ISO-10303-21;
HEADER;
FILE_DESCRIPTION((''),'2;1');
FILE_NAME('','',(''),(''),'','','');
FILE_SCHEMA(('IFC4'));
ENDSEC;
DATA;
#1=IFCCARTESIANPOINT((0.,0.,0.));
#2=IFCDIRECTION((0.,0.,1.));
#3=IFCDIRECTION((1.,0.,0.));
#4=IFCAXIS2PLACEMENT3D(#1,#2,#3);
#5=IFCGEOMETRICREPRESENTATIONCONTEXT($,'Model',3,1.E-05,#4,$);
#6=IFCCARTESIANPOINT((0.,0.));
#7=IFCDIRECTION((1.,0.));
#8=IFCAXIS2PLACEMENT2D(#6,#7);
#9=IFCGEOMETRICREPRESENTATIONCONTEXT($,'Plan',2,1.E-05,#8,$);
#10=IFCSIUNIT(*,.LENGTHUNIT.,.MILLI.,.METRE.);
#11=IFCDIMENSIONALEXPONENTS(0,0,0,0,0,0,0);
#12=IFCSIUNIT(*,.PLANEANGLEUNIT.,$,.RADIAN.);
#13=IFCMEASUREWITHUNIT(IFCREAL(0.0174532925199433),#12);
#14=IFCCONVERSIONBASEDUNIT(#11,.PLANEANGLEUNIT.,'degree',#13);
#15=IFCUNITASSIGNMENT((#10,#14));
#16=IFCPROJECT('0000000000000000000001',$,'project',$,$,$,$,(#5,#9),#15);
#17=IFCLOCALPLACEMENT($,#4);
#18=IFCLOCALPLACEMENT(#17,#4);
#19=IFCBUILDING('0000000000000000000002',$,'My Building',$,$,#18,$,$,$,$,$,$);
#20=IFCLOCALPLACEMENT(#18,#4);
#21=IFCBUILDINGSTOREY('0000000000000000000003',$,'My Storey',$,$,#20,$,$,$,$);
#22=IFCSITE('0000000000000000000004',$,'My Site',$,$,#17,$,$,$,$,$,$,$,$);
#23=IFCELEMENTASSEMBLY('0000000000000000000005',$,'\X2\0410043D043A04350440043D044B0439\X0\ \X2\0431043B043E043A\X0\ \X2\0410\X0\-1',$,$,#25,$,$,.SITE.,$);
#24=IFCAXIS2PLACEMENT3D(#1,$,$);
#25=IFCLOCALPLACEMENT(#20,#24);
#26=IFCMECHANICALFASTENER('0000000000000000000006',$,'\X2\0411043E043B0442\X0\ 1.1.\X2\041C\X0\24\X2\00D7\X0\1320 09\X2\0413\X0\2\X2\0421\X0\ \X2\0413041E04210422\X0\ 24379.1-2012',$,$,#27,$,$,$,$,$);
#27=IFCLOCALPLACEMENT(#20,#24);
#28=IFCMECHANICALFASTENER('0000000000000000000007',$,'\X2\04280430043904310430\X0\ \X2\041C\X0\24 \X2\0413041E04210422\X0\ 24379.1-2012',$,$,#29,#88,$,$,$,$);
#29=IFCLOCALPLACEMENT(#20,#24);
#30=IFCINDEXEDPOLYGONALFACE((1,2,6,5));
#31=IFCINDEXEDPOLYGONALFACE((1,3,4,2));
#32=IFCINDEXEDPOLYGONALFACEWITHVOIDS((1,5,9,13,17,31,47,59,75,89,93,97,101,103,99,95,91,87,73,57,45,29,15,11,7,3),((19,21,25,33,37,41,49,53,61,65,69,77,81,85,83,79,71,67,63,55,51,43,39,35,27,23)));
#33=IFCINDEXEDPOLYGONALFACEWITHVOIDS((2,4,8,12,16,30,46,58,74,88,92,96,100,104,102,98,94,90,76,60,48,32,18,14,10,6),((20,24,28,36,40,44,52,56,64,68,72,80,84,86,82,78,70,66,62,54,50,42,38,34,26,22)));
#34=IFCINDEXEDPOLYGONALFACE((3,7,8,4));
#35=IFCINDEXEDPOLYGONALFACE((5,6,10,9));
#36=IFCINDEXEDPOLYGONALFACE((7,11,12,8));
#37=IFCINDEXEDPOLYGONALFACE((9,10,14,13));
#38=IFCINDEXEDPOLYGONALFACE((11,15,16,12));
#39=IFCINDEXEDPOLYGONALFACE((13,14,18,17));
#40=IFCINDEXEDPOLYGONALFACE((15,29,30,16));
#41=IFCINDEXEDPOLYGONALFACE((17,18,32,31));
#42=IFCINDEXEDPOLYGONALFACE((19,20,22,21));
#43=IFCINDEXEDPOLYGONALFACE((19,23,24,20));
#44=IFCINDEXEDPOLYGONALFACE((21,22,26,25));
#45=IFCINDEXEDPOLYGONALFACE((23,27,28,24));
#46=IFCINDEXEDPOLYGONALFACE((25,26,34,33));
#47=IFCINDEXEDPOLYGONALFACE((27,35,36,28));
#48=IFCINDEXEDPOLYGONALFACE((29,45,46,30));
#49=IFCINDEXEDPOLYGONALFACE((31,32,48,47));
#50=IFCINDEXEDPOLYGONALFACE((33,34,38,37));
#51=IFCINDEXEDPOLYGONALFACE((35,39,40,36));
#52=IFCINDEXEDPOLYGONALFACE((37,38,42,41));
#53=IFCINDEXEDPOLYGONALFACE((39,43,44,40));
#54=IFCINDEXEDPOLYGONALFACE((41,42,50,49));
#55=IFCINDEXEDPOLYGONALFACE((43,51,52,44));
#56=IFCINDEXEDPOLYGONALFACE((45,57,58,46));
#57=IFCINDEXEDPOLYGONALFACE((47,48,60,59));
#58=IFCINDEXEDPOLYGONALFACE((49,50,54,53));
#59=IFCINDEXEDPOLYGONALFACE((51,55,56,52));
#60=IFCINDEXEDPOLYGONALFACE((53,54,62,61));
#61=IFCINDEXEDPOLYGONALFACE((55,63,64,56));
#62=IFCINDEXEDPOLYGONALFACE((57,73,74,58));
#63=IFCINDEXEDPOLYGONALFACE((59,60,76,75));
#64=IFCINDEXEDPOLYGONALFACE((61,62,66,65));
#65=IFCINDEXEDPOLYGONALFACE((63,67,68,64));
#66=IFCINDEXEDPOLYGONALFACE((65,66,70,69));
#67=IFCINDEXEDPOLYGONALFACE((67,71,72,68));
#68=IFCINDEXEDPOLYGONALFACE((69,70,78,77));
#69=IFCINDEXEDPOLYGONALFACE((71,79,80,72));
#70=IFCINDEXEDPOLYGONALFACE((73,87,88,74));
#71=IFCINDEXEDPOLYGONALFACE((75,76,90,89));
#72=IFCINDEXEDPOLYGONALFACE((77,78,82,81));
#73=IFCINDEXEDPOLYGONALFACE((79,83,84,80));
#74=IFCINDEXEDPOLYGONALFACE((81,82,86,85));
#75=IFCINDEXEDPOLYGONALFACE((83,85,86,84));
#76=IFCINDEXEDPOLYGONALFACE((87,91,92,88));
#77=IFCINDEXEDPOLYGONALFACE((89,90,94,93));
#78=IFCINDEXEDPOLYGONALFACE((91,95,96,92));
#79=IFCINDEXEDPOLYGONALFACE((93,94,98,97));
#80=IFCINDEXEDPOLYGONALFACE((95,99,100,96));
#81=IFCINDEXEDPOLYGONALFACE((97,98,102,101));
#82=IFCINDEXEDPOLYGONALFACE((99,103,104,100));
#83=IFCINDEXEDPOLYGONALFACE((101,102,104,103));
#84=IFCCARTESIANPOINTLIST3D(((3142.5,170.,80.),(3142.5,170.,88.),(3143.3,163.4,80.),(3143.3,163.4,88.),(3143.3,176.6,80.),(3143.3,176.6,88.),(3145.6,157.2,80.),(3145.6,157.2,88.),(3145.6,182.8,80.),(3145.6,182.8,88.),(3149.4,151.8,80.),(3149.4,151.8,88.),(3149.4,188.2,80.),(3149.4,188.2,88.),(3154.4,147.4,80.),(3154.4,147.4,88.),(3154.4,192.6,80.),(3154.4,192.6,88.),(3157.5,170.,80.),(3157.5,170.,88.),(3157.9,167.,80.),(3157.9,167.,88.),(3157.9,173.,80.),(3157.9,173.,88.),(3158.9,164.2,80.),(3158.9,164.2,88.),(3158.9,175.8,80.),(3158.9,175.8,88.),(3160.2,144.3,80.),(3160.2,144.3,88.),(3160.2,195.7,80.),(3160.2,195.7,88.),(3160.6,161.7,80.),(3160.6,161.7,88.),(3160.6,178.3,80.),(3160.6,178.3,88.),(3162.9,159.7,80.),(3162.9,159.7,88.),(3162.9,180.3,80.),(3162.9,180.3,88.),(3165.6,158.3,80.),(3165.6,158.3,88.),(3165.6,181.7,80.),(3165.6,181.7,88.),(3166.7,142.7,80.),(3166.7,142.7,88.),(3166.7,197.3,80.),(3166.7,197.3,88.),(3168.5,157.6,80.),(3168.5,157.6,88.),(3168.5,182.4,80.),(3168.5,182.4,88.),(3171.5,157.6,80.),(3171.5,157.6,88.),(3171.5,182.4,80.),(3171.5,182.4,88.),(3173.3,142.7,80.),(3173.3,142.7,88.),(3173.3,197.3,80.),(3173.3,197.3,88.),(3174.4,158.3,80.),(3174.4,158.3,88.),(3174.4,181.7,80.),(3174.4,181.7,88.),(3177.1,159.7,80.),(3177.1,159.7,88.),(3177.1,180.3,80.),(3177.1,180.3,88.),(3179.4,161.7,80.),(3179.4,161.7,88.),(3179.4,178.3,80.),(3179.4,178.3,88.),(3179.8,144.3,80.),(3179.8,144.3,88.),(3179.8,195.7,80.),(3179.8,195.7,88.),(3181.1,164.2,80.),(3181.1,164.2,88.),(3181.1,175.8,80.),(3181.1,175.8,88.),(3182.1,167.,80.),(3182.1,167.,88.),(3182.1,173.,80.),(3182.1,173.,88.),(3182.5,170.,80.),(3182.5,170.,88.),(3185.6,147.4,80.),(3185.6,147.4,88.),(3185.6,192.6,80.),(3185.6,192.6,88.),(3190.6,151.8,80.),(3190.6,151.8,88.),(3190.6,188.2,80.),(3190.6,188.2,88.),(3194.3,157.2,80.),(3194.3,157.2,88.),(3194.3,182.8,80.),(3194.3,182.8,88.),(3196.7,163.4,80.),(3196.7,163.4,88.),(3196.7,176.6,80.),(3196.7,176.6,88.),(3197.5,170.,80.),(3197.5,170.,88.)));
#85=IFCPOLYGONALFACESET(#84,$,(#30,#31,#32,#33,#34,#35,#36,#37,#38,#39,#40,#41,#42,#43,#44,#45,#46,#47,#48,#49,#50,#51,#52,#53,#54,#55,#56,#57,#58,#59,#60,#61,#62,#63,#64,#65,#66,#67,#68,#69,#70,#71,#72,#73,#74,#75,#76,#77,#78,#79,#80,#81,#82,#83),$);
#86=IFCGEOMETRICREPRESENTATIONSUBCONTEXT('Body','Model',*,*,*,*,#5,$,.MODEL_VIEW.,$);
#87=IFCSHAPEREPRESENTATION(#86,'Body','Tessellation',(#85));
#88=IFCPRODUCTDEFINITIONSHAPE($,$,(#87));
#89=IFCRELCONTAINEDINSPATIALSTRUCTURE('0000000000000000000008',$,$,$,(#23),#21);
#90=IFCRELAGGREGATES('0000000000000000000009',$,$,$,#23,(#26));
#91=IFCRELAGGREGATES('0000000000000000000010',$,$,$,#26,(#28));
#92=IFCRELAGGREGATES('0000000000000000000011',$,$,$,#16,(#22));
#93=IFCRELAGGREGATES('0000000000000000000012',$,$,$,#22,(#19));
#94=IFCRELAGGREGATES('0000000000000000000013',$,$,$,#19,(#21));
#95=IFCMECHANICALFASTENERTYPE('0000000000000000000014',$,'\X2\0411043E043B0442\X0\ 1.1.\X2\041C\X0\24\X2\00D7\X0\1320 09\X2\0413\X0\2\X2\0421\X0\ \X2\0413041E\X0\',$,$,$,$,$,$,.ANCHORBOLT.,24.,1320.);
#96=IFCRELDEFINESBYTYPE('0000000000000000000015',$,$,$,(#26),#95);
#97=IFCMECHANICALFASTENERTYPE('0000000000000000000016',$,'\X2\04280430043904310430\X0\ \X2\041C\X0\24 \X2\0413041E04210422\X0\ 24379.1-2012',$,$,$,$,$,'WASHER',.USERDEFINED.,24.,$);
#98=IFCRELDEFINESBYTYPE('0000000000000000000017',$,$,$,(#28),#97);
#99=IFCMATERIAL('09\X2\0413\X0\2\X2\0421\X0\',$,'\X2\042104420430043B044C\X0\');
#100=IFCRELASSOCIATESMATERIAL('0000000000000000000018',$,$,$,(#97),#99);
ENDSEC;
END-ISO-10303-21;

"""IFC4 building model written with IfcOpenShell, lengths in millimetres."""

from ifc_helpers import new_model, entity, si_unit, converted_unit, frame, origin_with_axes, origin_2d_with_axis, place, context, subcontext, project, spatial, polyline, outline, extrude, source, transform, mapped, material, type_object, type_shapes, element, aggregate, save


model = new_model("IFC4")

# Units and contexts
model_context = context("Model", 3, precision=1e-05, world=origin_with_axes())
plan_context = context("Plan", 2, precision=1e-05, world=origin_2d_with_axis())
body_context = subcontext(model_context, "Body", "Model", "MODEL_VIEW")
ifc_project = project(units=[si_unit("LENGTHUNIT", "METRE", prefix="MILLI"), converted_unit("PLANEANGLEUNIT", "degree", entity("IfcReal", 0.0174532925199433), si_unit("PLANEANGLEUNIT", "RADIAN"), dimensions=[0, 0, 0, 0, 0, 0, 0])], contexts=[model_context, plan_context])

# Site, building, storey
site_placement = place(None, origin_with_axes())
site = spatial("IfcSite", under=ifc_project, at=site_placement, Name="My Site")
building_placement = place(site_placement, origin_with_axes())
building = spatial("IfcBuilding", under=site, at=building_placement, Name="My Building")
storey_placement = place(building_placement, origin_with_axes())
storey = spatial("IfcBuildingStorey", under=building, at=storey_placement, Name="My Storey")

# Shared definitions
placement = place(storey_placement, frame((3000.0, 0.0, 0.0), z_axis=(0.0, 0.0, 1.0), x_axis=(1.0, 0.0, 0.0)))

# Element assembly, mechanical fasteners
assembly = element("IfcElementAssembly", 1, at=placement, inside=storey, Name="Анкерный блок А-1", AssemblyPlace="SITE")
mechanical_fastener_type_1 = type_object("IfcMechanicalFastenerType", Name="Болт 1.1.М24×1320 09Г2С ГО", NominalDiameter=24.0, NominalLength=1320.0, PredefinedType="ANCHORBOLT")
ifc_material_1 = material(Name="09Г2С", Category="Сталь")
mechanical_fastener_1_placement = place(placement, frame((170.0, 170.0, 0.0), z_axis=(0.0, 0.0, 1.0), x_axis=(-1.0, 0.0, 0.0)))
mechanical_fastener_1 = element("IfcMechanicalFastener", 2, at=mechanical_fastener_1_placement, type_object=mechanical_fastener_type_1, Name="Болт 1.1.М24×1320 09Г2С ГОСТ 24379.1-2012")
aggregate(assembly, [mechanical_fastener_1])
mechanical_fastener_type_2 = type_object("IfcMechanicalFastenerType", Name="Шайба М24 ГОСТ 24379.1-2012", ElementType="WASHER", NominalDiameter=24.0, PredefinedType="USERDEFINED", material=ifc_material_1)
shared_shape_1 = source(origin_with_axes(), body_context, "Body", "SweptSolid", [
    extrude(outline(polyline([(27.5, 0.0), (26.7, 6.6), (24.4, 12.8), (20.6, 18.2), (15.6, 22.6), (9.8, 25.7), (3.3, 27.3), (-3.3, 27.3), (-9.8, 25.7), (-15.6, 22.6), (-20.6, 18.2), (-24.4, 12.8), (-26.7, 6.6), (-27.5, 0.0), (-26.7, -6.6), (-24.4, -12.8), (-20.6, -18.2), (-15.6, -22.6), (-9.8, -25.7), (-3.3, -27.3), (3.3, -27.3), (9.8, -25.7), (15.6, -22.6), (20.6, -18.2), (24.4, -12.8), (26.7, -6.6), (27.5, 0.0)]), holes=[polyline([(-4.4, -11.7), (-7.1, -10.3), (-9.4, -8.3), (-11.1, -5.8), (-12.1, -3.0), (-12.5, 0.0), (-12.1, 3.0), (-11.1, 5.8), (-9.4, 8.3), (-7.1, 10.3), (-4.4, 11.7), (-1.5, 12.4), (1.5, 12.4), (4.4, 11.7), (7.1, 10.3), (9.4, 8.3), (11.1, 5.8), (12.1, 3.0), (12.5, 0.0), (12.1, -3.0), (11.1, -5.8), (9.4, -8.3), (7.1, -10.3), (4.4, -11.7), (1.5, -12.4), (-1.5, -12.4), (-4.4, -11.7)])]), frame((0.0, 0.0, 0.0), z_axis=(0.0, 0.0, 1.0), x_axis=(0.120537, -0.992709, 0.0)), (0.0, 0.0, 1.0), 8.0),
])
type_shapes(mechanical_fastener_type_2, [shared_shape_1])
mechanical_fastener_2_placement = place(mechanical_fastener_1_placement, frame((0.0, 0.0, 80.0), z_axis=(0.0, 0.0, 1.0), x_axis=(1.0, 0.0, 0.0)))
mechanical_fastener_2 = element("IfcMechanicalFastener", 3, at=mechanical_fastener_2_placement, type_object=mechanical_fastener_type_2, Name="Шайба М24 ГОСТ 24379.1-2012", context=body_context, shape_type="MappedRepresentation", body=[
    mapped(shared_shape_1, transform((0.0, 0.0, 0.0), x_axis=(1.0, 0.0, 0.0), y_axis=(0.0, 1.0, 0.0), z_axis=(0.0, 0.0, 1.0), scale=1.0)),
])
aggregate(mechanical_fastener_1, [mechanical_fastener_2])

save(model, "model.ifc")
